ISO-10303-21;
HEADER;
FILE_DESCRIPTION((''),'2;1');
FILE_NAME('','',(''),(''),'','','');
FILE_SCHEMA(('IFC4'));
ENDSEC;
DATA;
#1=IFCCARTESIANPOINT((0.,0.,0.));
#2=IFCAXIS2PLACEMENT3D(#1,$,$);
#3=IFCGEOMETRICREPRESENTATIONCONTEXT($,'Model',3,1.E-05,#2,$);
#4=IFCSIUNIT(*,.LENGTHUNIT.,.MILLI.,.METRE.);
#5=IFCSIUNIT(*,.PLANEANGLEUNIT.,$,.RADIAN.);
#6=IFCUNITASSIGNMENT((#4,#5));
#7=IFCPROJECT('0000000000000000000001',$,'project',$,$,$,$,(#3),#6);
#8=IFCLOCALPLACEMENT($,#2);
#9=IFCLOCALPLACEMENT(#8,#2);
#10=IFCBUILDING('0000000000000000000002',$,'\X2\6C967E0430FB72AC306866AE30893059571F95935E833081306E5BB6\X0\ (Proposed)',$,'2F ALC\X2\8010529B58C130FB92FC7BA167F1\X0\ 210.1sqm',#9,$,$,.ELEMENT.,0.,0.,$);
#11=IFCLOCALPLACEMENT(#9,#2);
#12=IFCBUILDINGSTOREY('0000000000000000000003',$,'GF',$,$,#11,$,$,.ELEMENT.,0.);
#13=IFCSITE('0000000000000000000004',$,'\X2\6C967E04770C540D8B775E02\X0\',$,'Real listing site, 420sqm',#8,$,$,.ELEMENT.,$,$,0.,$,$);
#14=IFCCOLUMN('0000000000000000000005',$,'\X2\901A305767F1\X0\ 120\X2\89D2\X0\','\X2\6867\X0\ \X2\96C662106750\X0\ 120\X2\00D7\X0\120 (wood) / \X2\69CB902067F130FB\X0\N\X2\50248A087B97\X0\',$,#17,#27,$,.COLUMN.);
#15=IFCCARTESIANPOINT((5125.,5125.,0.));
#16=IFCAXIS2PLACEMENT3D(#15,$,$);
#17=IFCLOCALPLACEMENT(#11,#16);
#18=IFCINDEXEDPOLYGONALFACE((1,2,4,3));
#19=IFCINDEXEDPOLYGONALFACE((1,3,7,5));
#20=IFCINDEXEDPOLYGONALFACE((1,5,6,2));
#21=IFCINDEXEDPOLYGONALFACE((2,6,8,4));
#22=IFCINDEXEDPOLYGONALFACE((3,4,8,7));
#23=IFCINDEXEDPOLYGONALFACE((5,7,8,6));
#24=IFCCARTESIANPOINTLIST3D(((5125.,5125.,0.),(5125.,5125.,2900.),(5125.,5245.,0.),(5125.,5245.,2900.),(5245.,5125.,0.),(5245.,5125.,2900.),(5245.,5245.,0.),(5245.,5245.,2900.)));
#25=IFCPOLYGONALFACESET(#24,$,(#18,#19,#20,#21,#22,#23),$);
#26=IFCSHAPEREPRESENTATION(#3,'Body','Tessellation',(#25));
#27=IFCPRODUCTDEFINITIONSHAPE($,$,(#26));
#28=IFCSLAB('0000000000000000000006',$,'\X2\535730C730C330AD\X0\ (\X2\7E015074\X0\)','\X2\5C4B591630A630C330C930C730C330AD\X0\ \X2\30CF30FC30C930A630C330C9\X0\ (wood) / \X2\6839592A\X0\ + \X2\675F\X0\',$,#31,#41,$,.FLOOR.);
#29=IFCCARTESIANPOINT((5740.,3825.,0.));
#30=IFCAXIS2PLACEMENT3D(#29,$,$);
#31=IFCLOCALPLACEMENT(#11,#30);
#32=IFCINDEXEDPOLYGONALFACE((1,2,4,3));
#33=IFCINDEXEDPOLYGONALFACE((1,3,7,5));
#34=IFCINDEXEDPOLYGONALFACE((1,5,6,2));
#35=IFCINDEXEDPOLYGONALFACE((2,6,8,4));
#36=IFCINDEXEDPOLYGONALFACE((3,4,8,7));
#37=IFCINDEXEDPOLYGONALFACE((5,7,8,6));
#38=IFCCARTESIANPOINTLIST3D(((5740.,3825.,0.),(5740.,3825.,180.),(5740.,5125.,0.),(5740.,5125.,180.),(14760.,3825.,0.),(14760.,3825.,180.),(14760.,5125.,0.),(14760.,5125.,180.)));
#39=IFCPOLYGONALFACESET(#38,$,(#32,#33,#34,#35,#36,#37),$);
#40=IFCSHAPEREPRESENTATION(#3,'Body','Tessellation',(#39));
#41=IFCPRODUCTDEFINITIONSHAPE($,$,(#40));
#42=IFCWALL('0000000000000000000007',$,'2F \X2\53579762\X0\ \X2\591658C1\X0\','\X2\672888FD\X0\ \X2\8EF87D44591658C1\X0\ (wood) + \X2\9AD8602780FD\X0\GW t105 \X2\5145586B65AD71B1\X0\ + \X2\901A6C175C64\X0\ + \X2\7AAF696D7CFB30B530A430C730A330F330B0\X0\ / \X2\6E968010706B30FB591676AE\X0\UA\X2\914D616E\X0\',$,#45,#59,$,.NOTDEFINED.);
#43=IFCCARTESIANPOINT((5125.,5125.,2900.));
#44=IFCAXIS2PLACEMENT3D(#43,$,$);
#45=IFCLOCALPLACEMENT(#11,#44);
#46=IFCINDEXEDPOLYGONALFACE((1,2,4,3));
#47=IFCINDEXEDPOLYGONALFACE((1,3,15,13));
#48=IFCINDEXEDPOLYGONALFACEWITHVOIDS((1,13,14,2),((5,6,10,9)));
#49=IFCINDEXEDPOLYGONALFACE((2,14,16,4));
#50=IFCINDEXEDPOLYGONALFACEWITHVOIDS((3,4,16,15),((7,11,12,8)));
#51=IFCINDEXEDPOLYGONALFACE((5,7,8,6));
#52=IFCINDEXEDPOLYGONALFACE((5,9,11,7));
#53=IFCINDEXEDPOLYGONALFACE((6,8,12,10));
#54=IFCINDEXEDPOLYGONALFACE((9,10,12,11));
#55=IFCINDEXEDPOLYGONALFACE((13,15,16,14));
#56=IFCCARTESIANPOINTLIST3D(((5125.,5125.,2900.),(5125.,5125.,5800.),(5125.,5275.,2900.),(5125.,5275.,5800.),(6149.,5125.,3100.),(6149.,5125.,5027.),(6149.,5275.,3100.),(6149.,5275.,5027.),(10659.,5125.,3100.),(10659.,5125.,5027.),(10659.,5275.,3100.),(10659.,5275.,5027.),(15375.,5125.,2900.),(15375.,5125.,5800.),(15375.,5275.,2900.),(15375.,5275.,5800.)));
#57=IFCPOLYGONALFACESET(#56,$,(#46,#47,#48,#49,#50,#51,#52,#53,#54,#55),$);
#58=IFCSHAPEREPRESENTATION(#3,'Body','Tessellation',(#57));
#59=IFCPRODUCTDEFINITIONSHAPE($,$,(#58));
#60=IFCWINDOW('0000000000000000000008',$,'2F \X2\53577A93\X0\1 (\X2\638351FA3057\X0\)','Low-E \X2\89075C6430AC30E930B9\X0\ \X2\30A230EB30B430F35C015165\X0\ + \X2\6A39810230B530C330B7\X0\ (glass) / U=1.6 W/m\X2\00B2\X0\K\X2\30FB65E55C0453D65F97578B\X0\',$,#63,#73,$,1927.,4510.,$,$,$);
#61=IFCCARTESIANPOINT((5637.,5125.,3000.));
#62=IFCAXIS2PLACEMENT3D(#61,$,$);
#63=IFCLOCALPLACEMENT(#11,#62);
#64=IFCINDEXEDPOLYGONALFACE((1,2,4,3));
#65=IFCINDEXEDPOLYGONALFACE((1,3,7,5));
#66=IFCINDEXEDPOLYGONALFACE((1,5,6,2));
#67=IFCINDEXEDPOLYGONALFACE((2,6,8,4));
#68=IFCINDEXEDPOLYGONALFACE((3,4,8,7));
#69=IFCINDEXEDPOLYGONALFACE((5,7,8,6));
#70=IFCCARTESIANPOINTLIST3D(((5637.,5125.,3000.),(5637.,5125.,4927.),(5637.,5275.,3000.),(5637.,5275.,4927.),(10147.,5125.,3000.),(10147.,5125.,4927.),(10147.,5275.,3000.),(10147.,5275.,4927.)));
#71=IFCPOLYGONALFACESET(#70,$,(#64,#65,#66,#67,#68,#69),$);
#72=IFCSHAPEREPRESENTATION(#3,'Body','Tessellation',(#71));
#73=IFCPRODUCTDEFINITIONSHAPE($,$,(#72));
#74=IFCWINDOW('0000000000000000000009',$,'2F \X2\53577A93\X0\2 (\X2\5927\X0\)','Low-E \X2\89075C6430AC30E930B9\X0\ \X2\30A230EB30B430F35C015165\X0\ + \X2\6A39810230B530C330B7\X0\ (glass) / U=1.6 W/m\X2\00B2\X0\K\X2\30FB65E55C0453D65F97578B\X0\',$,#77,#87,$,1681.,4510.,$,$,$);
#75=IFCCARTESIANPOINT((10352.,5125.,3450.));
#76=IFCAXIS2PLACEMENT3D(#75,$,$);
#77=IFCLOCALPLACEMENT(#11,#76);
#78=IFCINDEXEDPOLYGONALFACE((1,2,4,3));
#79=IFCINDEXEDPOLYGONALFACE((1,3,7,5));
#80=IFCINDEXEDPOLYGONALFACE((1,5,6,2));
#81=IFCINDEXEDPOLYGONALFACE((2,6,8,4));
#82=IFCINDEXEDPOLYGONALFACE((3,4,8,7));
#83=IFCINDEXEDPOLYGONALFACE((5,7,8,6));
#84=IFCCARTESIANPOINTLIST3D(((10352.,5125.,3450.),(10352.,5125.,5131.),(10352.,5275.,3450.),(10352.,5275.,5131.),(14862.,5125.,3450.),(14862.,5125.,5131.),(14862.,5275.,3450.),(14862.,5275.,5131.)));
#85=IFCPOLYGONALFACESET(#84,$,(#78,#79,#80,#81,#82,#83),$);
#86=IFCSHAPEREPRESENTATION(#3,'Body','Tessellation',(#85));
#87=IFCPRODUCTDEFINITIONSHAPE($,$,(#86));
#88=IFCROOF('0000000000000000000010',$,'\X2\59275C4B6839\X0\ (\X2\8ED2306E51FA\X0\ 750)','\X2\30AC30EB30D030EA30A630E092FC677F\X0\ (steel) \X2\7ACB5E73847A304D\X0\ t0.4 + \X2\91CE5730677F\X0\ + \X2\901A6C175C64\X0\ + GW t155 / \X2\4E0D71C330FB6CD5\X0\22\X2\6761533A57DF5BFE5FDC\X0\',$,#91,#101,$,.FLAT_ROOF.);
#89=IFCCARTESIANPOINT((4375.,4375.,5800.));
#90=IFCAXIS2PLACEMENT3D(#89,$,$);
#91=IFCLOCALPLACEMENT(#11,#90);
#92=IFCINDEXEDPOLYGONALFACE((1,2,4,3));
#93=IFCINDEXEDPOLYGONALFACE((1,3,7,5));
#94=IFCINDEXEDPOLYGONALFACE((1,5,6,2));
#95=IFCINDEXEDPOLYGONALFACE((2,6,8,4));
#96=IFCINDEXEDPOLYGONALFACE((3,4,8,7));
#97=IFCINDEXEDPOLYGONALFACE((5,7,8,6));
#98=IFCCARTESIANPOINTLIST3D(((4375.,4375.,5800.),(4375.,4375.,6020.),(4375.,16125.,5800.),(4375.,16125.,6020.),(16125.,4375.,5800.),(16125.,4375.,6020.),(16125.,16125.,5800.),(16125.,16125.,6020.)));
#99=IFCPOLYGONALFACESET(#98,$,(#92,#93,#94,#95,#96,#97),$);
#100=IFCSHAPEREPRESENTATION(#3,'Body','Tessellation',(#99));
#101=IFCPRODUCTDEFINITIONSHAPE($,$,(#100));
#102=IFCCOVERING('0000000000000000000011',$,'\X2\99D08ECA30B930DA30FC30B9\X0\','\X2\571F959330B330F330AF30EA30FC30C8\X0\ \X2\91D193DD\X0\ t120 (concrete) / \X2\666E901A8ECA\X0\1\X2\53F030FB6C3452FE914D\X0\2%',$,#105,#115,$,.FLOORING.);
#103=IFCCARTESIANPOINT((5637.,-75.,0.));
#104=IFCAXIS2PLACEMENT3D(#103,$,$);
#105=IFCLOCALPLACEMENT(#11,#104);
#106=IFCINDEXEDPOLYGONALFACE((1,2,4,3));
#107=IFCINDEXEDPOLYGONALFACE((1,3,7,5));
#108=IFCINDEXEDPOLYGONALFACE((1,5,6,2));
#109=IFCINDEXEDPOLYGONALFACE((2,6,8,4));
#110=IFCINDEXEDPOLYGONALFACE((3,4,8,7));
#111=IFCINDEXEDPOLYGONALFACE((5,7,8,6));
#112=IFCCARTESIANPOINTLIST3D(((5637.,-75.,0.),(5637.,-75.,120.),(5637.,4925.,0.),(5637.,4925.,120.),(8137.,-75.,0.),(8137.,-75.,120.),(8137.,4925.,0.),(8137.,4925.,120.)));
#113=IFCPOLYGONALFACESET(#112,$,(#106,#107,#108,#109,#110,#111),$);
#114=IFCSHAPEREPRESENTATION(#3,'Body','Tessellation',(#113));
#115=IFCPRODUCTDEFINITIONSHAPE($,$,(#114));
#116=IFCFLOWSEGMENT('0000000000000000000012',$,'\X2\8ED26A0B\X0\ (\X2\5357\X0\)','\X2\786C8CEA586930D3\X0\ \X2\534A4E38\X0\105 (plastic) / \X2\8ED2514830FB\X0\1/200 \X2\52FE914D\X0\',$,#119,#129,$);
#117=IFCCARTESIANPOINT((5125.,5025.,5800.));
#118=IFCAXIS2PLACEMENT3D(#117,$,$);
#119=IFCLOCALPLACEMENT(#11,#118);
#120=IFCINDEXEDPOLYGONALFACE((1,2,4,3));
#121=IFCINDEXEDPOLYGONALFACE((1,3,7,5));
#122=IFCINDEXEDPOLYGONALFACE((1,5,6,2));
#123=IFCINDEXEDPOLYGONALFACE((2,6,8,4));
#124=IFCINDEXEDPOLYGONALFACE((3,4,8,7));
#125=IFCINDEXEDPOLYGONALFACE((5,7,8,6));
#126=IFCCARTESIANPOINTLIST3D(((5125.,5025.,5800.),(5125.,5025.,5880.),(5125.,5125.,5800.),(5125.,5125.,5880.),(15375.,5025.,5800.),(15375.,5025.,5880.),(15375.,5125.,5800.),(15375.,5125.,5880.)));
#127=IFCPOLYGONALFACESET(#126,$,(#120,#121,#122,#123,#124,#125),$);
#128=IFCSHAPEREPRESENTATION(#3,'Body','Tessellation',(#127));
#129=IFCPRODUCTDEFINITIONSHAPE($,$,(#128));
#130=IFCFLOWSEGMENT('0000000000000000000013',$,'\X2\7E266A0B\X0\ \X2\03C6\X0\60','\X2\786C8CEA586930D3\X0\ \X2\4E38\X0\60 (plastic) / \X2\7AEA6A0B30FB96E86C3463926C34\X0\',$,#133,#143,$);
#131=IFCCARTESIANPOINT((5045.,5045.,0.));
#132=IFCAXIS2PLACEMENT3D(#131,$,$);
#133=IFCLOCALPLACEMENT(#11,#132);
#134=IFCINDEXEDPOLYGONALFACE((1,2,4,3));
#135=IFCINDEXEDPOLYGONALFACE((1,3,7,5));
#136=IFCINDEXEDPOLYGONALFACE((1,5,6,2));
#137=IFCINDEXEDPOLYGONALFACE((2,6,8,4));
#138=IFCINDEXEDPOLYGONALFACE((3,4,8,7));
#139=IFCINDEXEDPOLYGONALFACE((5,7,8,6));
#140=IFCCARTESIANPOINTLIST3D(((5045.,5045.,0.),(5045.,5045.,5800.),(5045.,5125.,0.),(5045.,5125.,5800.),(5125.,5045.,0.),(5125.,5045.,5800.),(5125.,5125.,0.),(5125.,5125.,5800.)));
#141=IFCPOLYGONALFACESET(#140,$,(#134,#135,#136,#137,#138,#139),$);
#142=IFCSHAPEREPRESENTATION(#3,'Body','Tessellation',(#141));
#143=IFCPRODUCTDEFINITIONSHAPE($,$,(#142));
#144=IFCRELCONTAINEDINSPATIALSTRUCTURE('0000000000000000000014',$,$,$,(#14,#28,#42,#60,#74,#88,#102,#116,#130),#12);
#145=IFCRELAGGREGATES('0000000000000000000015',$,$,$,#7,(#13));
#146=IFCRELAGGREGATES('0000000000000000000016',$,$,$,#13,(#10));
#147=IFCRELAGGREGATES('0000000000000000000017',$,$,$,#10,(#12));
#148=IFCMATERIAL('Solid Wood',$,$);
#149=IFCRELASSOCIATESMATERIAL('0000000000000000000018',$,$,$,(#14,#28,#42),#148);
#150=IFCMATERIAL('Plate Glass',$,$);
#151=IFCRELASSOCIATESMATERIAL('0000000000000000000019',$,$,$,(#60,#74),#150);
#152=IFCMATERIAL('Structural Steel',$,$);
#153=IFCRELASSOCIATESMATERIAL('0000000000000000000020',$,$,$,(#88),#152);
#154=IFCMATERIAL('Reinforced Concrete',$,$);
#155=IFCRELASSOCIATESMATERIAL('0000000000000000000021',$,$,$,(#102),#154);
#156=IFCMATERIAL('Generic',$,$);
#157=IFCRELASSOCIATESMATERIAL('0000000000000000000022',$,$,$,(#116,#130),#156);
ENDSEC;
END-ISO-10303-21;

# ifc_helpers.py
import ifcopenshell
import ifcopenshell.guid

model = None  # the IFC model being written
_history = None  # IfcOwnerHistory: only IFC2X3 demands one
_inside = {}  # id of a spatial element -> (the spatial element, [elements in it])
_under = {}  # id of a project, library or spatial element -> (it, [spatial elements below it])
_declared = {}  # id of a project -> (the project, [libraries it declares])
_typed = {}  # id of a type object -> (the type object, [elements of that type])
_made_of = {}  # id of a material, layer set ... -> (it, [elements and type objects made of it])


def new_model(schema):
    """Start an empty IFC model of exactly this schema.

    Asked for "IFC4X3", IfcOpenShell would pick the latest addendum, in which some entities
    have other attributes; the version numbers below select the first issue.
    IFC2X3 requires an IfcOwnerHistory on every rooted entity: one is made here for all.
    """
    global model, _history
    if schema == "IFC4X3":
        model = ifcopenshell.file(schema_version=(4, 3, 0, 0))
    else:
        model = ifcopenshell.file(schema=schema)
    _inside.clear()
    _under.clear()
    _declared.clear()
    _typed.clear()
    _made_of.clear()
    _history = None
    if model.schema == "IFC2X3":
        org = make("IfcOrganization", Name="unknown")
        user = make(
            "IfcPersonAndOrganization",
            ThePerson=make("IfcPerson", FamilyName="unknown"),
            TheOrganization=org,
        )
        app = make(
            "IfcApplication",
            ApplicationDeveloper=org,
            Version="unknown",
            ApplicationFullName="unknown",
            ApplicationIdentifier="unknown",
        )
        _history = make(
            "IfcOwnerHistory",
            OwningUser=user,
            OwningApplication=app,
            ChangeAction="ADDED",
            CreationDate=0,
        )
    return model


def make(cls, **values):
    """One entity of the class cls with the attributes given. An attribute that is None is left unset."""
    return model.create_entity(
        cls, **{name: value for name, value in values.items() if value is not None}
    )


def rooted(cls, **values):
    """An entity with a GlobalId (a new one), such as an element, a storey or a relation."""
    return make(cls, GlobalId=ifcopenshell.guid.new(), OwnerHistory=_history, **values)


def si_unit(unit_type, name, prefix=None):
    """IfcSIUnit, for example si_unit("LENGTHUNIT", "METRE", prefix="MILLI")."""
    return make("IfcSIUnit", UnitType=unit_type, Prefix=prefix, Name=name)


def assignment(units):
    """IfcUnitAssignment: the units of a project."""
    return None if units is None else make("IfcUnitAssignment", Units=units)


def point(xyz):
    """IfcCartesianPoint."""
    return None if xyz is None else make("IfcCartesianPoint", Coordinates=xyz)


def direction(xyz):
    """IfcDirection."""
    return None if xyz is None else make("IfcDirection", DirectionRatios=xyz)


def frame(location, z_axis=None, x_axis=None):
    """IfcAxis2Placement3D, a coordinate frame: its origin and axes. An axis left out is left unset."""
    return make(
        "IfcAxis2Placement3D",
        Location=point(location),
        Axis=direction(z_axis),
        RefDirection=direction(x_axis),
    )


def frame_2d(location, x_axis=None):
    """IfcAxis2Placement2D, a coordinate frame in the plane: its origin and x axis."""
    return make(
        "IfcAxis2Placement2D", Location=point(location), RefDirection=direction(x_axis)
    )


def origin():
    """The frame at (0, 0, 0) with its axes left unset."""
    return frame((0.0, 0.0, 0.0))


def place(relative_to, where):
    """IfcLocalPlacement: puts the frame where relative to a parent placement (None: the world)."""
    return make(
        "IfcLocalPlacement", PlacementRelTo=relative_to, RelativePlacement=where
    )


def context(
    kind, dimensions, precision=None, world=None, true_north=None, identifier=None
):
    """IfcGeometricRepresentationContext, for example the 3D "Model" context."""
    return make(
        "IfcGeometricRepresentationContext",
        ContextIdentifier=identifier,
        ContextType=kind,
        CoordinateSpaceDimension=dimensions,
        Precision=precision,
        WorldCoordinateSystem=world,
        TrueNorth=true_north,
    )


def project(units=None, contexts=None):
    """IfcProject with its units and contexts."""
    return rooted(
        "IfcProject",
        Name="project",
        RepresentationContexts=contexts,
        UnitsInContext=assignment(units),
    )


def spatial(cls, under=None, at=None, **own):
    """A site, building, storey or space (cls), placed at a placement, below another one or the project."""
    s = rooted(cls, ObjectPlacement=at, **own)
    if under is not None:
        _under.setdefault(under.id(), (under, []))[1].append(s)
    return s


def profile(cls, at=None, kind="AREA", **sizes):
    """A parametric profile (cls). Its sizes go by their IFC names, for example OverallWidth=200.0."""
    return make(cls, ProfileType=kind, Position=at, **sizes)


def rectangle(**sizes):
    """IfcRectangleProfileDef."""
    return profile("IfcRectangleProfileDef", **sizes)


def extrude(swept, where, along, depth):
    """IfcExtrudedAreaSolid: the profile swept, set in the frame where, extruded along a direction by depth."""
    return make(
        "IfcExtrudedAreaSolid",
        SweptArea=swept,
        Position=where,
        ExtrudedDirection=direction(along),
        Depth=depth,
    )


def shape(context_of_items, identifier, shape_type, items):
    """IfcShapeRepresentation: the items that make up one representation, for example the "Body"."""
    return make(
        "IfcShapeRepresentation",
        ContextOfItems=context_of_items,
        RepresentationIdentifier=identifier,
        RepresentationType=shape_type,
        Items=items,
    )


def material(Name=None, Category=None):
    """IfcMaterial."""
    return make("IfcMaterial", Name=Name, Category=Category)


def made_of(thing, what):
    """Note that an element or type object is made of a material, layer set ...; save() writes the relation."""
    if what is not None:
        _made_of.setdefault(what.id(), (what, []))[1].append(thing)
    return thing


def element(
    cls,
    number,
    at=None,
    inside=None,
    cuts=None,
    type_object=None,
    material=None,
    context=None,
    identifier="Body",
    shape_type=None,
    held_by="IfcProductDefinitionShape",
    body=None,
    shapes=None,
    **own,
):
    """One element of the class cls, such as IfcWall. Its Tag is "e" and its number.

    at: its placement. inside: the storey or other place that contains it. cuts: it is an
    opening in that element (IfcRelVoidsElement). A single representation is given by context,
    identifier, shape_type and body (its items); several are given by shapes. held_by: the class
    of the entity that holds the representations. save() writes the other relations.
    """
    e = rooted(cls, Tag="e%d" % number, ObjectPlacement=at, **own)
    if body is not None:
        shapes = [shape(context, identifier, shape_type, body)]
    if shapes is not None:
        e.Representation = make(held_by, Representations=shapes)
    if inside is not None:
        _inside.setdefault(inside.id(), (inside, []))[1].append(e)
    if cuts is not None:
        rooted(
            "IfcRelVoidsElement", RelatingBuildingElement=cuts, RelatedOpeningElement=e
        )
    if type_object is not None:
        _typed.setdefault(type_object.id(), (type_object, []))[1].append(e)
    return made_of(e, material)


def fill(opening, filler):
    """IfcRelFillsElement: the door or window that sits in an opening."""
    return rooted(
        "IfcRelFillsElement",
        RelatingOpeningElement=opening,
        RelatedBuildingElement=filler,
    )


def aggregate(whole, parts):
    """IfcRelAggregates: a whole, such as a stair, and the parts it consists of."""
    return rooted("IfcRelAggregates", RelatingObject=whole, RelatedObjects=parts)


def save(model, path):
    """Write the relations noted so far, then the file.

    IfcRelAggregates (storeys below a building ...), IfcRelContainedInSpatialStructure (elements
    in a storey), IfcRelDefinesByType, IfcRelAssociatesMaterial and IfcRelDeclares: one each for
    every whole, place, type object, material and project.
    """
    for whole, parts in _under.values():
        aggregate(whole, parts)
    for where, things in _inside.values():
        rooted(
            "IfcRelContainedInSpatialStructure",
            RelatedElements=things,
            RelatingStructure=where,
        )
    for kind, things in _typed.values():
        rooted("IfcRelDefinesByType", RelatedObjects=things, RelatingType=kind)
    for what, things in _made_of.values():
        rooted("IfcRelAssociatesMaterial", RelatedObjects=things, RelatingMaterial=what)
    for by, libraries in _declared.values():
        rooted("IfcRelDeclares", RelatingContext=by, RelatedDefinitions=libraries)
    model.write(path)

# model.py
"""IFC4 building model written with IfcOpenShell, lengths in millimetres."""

from ifc_helpers import new_model, si_unit, frame, frame_2d, origin, place, context, project, spatial, rectangle, extrude, material, element, fill, save


model = new_model("IFC4")

# Units and contexts
model_context = context("Model", 3, precision=1e-05, world=origin())
ifc_project = project(units=[si_unit("LENGTHUNIT", "METRE", prefix="MILLI"), si_unit("PLANEANGLEUNIT", "RADIAN")], contexts=[model_context])

# Site, building, storey
site_placement = place(None, origin())
site = spatial("IfcSite", under=ifc_project, at=site_placement, Name="沖縄県名護市", ObjectType="Real listing site, 420sqm", CompositionType="ELEMENT", RefElevation=0.0)
building_placement = place(site_placement, origin())
building = spatial("IfcBuilding", under=site, at=building_placement, Name="沖縄・犬と暮らす土間広めの家 (Proposed)", ObjectType="2F ALC耐力壁・鋼管柱 210.1sqm", CompositionType="ELEMENT", ElevationOfRefHeight=0.0, ElevationOfTerrain=0.0)
storey_placement = place(building_placement, origin())
storey = spatial("IfcBuildingStorey", under=building, at=storey_placement, Name="GF", CompositionType="ELEMENT", Elevation=0.0)

# Column
ifc_material_1 = material(Name="Solid Wood")
column_placement = place(storey_placement, frame((5125.0, 5125.0, 0.0)))
element("IfcColumn", 1, at=column_placement, inside=storey, material=ifc_material_1, Name="通し柱 120角", Description="桧 集成材 120×120 (wood) / 構造柱・N値計算", PredefinedType="COLUMN", context=model_context, shape_type="SweptSolid", body=[
    extrude(rectangle(XDim=120.0, YDim=120.0, at=frame_2d((60.0, 60.0))), frame((5125.0, 5125.0, 0.0)), (0.0, 0.0, 1.0), 2900.0),
])

# Slab
ifc_material_2 = material(Name="Reinforced Concrete")
slab_1_placement = place(storey_placement, frame((5740.0, 3825.0, 0.0)))
element("IfcSlab", 2, at=slab_1_placement, inside=storey, material=ifc_material_1, Name="南デッキ (縁側)", Description="屋外ウッドデッキ ハードウッド (wood) / 根太 + 束", PredefinedType="FLOOR", context=model_context, shape_type="SweptSolid", body=[
    extrude(rectangle(XDim=9020.0, YDim=1300.0, at=frame_2d((4510.0, 650.0))), frame((5740.0, 3825.0, 0.0)), (0.0, 0.0, 1.0), 180.0),
])

# Shared definitions
ifc_material_3 = material(Name="Plate Glass")

# Wall, openings, windows
wall_1_placement = place(storey_placement, frame((5125.0, 5125.0, 2900.0)))
wall_1 = element("IfcWall", 3, at=wall_1_placement, inside=storey, material=ifc_material_1, Name="2F 南面 外壁", Description="木製 軸組外壁 (wood) + 高性能GW t105 充填断熱 + 通気層 + 窯業系サイディング / 準耐火・外皮UA配慮", PredefinedType="NOTDEFINED", context=model_context, shape_type="SweptSolid", body=[
    extrude(rectangle(XDim=10250.0, YDim=150.0, at=frame_2d((5125.0, 75.0))), frame((5125.0, 5125.0, 2900.0)), (0.0, 0.0, 1.0), 2900.0),
])
opening_1_placement = place(storey_placement, frame((5637.0, 5125.0, 3000.0)))
opening_1 = element("IfcOpeningElement", 4, at=opening_1_placement, cuts=wall_1, PredefinedType="NOTDEFINED", context=model_context, shape_type="SweptSolid", body=[
    extrude(rectangle(XDim=4510.0, YDim=150.0, at=frame_2d((2255.0, 75.0))), frame((5637.0, 5125.0, 3000.0)), (0.0, 0.0, 1.0), 1927.0),
])
opening_2_placement = place(storey_placement, frame((10352.0, 5125.0, 3450.0)))
opening_2 = element("IfcOpeningElement", 5, at=opening_2_placement, cuts=wall_1, PredefinedType="NOTDEFINED", context=model_context, shape_type="SweptSolid", body=[
    extrude(rectangle(XDim=4510.0, YDim=150.0, at=frame_2d((2255.0, 75.0))), frame((10352.0, 5125.0, 3450.0)), (0.0, 0.0, 1.0), 1681.0),
])
window_1_placement = place(storey_placement, frame((5637.0, 5125.0, 3000.0)))
window_1 = element("IfcWindow", 6, at=window_1_placement, inside=storey, material=ifc_material_3, Name="2F 南窓1 (掃出し)", Description="Low-E 複層ガラス アルゴン封入 + 樹脂サッシ (glass) / U=1.6 W/m²K・日射取得型", OverallHeight=1927.0, OverallWidth=4510.0, context=model_context, shape_type="SweptSolid", body=[
    extrude(rectangle(XDim=4510.0, YDim=150.0, at=frame_2d((2255.0, 75.0))), frame((5637.0, 5125.0, 3000.0)), (0.0, 0.0, 1.0), 1927.0),
])
fill(opening_1, window_1)
window_2_placement = place(storey_placement, frame((10352.0, 5125.0, 3450.0)))
window_2 = element("IfcWindow", 7, at=window_2_placement, inside=storey, material=ifc_material_3, Name="2F 南窓2 (大)", Description="Low-E 複層ガラス アルゴン封入 + 樹脂サッシ (glass) / U=1.6 W/m²K・日射取得型", OverallHeight=1681.0, OverallWidth=4510.0, context=model_context, shape_type="SweptSolid", body=[
    extrude(rectangle(XDim=4510.0, YDim=150.0, at=frame_2d((2255.0, 75.0))), frame((10352.0, 5125.0, 3450.0)), (0.0, 0.0, 1.0), 1681.0),
])
fill(opening_2, window_2)

# Roof
ifc_material_4 = material(Name="Structural Steel")
roof_placement = place(storey_placement, frame((4375.0, 4375.0, 5800.0)))
element("IfcRoof", 8, at=roof_placement, inside=storey, material=ifc_material_4, Name="大屋根 (軒の出 750)", Description="ガルバリウム鋼板 (steel) 立平葺き t0.4 + 野地板 + 通気層 + GW t155 / 不燃・法22条区域対応", PredefinedType="FLAT_ROOF", context=model_context, shape_type="SweptSolid", body=[
    extrude(rectangle(XDim=11750.0, YDim=11750.0, at=frame_2d((5875.0, 5875.0))), frame((4375.0, 4375.0, 5800.0)), (0.0, 0.0, 1.0), 220.0),
])

# Covering
covering_placement = place(storey_placement, frame((5637.0, -75.0, 0.0)))
element("IfcCovering", 9, at=covering_placement, inside=storey, material=ifc_material_2, Name="駐車スペース", Description="土間コンクリート 金鏝 t120 (concrete) / 普通車1台・水勾配2%", PredefinedType="FLOORING", context=model_context, shape_type="SweptSolid", body=[
    extrude(rectangle(XDim=2500.0, YDim=5000.0, at=frame_2d((1250.0, 2500.0))), frame((5637.0, -75.0, 0.0)), (0.0, 0.0, 1.0), 120.0),
])

# Flow segments
ifc_material_5 = material(Name="Generic")
flow_segment_1_placement = place(storey_placement, frame((5125.0, 5025.0, 5800.0)))
element("IfcFlowSegment", 10, at=flow_segment_1_placement, inside=storey, material=ifc_material_5, Name="軒樋 (南)", Description="硬質塩ビ 半丸105 (plastic) / 軒先・1/200 勾配", context=model_context, shape_type="SweptSolid", body=[
    extrude(rectangle(XDim=10250.0, YDim=100.0, at=frame_2d((5125.0, 50.0))), frame((5125.0, 5025.0, 5800.0)), (0.0, 0.0, 1.0), 80.0),
])
flow_segment_2_placement = place(storey_placement, frame((5045.0, 5045.0, 0.0)))
element("IfcFlowSegment", 11, at=flow_segment_2_placement, inside=storey, material=ifc_material_5, Name="縦樋 φ60", Description="硬質塩ビ 丸60 (plastic) / 竪樋・雨水排水", context=model_context, shape_type="SweptSolid", body=[
    extrude(rectangle(XDim=80.0, YDim=80.0, at=frame_2d((40.0, 40.0))), frame((5045.0, 5045.0, 0.0)), (0.0, 0.0, 1.0), 5800.0),
])

save(model, "model.ifc")
